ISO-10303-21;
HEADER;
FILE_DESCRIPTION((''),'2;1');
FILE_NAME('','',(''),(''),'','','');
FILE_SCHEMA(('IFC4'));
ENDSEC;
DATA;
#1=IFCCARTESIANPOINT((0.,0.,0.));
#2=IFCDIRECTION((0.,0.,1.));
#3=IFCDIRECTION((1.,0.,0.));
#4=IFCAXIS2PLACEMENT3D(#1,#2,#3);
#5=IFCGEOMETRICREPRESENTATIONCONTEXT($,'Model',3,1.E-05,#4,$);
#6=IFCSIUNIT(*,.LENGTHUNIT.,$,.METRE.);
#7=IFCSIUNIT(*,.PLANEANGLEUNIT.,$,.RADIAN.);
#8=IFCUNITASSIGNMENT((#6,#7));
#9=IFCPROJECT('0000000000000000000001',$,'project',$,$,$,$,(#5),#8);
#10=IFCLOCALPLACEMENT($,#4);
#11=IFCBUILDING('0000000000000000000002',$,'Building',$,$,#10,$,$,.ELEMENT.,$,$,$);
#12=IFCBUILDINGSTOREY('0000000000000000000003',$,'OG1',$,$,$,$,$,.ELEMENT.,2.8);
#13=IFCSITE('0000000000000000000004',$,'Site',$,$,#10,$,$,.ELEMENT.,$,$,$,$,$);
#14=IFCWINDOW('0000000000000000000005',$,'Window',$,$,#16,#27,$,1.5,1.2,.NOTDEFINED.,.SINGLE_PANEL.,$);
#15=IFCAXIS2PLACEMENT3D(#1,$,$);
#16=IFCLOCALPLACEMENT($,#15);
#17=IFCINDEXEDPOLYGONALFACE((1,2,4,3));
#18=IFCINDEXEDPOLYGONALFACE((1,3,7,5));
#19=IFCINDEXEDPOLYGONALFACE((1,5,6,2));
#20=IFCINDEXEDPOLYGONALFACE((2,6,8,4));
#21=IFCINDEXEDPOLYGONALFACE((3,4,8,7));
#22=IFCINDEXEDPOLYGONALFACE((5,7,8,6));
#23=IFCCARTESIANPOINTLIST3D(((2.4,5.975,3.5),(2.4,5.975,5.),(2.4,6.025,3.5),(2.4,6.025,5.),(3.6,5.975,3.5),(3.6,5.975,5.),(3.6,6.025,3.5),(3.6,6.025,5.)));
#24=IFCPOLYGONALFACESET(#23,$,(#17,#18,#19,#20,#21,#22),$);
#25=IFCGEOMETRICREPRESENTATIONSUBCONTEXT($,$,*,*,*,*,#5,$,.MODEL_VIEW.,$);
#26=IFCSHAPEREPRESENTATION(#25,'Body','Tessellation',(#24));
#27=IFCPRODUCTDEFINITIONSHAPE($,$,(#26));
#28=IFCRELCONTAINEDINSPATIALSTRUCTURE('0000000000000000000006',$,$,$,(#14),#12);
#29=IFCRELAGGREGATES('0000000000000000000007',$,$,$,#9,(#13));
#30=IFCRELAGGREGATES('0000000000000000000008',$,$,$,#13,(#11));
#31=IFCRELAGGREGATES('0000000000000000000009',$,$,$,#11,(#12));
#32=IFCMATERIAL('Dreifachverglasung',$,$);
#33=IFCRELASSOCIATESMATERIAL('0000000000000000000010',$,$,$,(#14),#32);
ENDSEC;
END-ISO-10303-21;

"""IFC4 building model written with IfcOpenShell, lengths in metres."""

from ifc_helpers import new_model, si_unit, frame, origin, origin_with_axes, origin_2d, place, context, subcontext, project, spatial, rectangle, extrude, material, element, save


model = new_model("IFC4")

# Units and contexts
model_context = context("Model", 3, precision=1e-05, world=origin_with_axes())
sub_context = subcontext(model_context, None, None, "MODEL_VIEW")
ifc_project = project(units=[si_unit("LENGTHUNIT", "METRE"), si_unit("PLANEANGLEUNIT", "RADIAN")], contexts=[model_context])

# Site, building, storey
placement_1 = place(None, origin_with_axes())
site = spatial("IfcSite", under=ifc_project, at=placement_1, Name="Site", CompositionType="ELEMENT")
building = spatial("IfcBuilding", under=site, at=placement_1, Name="Building", CompositionType="ELEMENT")
storey = spatial("IfcBuildingStorey", under=building, Name="OG1", CompositionType="ELEMENT", Elevation=2.8)

# Window
ifc_material = material(Name="Dreifachverglasung")
placement_2 = place(None, origin_with_axes())
window_placement = place(placement_2, frame((3.0, 6.0, 3.5)))
element("IfcWindow", 1, at=window_placement, inside=storey, material=ifc_material, Name="Window", OverallHeight=1.5, OverallWidth=1.2, PartitioningType="SINGLE_PANEL", PredefinedType="NOTDEFINED", context=sub_context, shape_type="SweptSolid", body=[
    extrude(rectangle(XDim=1.2, YDim=0.05, at=origin_2d()), origin(), (0.0, 0.0, 1.0), 1.5),
])

save(model, "model.ifc")
